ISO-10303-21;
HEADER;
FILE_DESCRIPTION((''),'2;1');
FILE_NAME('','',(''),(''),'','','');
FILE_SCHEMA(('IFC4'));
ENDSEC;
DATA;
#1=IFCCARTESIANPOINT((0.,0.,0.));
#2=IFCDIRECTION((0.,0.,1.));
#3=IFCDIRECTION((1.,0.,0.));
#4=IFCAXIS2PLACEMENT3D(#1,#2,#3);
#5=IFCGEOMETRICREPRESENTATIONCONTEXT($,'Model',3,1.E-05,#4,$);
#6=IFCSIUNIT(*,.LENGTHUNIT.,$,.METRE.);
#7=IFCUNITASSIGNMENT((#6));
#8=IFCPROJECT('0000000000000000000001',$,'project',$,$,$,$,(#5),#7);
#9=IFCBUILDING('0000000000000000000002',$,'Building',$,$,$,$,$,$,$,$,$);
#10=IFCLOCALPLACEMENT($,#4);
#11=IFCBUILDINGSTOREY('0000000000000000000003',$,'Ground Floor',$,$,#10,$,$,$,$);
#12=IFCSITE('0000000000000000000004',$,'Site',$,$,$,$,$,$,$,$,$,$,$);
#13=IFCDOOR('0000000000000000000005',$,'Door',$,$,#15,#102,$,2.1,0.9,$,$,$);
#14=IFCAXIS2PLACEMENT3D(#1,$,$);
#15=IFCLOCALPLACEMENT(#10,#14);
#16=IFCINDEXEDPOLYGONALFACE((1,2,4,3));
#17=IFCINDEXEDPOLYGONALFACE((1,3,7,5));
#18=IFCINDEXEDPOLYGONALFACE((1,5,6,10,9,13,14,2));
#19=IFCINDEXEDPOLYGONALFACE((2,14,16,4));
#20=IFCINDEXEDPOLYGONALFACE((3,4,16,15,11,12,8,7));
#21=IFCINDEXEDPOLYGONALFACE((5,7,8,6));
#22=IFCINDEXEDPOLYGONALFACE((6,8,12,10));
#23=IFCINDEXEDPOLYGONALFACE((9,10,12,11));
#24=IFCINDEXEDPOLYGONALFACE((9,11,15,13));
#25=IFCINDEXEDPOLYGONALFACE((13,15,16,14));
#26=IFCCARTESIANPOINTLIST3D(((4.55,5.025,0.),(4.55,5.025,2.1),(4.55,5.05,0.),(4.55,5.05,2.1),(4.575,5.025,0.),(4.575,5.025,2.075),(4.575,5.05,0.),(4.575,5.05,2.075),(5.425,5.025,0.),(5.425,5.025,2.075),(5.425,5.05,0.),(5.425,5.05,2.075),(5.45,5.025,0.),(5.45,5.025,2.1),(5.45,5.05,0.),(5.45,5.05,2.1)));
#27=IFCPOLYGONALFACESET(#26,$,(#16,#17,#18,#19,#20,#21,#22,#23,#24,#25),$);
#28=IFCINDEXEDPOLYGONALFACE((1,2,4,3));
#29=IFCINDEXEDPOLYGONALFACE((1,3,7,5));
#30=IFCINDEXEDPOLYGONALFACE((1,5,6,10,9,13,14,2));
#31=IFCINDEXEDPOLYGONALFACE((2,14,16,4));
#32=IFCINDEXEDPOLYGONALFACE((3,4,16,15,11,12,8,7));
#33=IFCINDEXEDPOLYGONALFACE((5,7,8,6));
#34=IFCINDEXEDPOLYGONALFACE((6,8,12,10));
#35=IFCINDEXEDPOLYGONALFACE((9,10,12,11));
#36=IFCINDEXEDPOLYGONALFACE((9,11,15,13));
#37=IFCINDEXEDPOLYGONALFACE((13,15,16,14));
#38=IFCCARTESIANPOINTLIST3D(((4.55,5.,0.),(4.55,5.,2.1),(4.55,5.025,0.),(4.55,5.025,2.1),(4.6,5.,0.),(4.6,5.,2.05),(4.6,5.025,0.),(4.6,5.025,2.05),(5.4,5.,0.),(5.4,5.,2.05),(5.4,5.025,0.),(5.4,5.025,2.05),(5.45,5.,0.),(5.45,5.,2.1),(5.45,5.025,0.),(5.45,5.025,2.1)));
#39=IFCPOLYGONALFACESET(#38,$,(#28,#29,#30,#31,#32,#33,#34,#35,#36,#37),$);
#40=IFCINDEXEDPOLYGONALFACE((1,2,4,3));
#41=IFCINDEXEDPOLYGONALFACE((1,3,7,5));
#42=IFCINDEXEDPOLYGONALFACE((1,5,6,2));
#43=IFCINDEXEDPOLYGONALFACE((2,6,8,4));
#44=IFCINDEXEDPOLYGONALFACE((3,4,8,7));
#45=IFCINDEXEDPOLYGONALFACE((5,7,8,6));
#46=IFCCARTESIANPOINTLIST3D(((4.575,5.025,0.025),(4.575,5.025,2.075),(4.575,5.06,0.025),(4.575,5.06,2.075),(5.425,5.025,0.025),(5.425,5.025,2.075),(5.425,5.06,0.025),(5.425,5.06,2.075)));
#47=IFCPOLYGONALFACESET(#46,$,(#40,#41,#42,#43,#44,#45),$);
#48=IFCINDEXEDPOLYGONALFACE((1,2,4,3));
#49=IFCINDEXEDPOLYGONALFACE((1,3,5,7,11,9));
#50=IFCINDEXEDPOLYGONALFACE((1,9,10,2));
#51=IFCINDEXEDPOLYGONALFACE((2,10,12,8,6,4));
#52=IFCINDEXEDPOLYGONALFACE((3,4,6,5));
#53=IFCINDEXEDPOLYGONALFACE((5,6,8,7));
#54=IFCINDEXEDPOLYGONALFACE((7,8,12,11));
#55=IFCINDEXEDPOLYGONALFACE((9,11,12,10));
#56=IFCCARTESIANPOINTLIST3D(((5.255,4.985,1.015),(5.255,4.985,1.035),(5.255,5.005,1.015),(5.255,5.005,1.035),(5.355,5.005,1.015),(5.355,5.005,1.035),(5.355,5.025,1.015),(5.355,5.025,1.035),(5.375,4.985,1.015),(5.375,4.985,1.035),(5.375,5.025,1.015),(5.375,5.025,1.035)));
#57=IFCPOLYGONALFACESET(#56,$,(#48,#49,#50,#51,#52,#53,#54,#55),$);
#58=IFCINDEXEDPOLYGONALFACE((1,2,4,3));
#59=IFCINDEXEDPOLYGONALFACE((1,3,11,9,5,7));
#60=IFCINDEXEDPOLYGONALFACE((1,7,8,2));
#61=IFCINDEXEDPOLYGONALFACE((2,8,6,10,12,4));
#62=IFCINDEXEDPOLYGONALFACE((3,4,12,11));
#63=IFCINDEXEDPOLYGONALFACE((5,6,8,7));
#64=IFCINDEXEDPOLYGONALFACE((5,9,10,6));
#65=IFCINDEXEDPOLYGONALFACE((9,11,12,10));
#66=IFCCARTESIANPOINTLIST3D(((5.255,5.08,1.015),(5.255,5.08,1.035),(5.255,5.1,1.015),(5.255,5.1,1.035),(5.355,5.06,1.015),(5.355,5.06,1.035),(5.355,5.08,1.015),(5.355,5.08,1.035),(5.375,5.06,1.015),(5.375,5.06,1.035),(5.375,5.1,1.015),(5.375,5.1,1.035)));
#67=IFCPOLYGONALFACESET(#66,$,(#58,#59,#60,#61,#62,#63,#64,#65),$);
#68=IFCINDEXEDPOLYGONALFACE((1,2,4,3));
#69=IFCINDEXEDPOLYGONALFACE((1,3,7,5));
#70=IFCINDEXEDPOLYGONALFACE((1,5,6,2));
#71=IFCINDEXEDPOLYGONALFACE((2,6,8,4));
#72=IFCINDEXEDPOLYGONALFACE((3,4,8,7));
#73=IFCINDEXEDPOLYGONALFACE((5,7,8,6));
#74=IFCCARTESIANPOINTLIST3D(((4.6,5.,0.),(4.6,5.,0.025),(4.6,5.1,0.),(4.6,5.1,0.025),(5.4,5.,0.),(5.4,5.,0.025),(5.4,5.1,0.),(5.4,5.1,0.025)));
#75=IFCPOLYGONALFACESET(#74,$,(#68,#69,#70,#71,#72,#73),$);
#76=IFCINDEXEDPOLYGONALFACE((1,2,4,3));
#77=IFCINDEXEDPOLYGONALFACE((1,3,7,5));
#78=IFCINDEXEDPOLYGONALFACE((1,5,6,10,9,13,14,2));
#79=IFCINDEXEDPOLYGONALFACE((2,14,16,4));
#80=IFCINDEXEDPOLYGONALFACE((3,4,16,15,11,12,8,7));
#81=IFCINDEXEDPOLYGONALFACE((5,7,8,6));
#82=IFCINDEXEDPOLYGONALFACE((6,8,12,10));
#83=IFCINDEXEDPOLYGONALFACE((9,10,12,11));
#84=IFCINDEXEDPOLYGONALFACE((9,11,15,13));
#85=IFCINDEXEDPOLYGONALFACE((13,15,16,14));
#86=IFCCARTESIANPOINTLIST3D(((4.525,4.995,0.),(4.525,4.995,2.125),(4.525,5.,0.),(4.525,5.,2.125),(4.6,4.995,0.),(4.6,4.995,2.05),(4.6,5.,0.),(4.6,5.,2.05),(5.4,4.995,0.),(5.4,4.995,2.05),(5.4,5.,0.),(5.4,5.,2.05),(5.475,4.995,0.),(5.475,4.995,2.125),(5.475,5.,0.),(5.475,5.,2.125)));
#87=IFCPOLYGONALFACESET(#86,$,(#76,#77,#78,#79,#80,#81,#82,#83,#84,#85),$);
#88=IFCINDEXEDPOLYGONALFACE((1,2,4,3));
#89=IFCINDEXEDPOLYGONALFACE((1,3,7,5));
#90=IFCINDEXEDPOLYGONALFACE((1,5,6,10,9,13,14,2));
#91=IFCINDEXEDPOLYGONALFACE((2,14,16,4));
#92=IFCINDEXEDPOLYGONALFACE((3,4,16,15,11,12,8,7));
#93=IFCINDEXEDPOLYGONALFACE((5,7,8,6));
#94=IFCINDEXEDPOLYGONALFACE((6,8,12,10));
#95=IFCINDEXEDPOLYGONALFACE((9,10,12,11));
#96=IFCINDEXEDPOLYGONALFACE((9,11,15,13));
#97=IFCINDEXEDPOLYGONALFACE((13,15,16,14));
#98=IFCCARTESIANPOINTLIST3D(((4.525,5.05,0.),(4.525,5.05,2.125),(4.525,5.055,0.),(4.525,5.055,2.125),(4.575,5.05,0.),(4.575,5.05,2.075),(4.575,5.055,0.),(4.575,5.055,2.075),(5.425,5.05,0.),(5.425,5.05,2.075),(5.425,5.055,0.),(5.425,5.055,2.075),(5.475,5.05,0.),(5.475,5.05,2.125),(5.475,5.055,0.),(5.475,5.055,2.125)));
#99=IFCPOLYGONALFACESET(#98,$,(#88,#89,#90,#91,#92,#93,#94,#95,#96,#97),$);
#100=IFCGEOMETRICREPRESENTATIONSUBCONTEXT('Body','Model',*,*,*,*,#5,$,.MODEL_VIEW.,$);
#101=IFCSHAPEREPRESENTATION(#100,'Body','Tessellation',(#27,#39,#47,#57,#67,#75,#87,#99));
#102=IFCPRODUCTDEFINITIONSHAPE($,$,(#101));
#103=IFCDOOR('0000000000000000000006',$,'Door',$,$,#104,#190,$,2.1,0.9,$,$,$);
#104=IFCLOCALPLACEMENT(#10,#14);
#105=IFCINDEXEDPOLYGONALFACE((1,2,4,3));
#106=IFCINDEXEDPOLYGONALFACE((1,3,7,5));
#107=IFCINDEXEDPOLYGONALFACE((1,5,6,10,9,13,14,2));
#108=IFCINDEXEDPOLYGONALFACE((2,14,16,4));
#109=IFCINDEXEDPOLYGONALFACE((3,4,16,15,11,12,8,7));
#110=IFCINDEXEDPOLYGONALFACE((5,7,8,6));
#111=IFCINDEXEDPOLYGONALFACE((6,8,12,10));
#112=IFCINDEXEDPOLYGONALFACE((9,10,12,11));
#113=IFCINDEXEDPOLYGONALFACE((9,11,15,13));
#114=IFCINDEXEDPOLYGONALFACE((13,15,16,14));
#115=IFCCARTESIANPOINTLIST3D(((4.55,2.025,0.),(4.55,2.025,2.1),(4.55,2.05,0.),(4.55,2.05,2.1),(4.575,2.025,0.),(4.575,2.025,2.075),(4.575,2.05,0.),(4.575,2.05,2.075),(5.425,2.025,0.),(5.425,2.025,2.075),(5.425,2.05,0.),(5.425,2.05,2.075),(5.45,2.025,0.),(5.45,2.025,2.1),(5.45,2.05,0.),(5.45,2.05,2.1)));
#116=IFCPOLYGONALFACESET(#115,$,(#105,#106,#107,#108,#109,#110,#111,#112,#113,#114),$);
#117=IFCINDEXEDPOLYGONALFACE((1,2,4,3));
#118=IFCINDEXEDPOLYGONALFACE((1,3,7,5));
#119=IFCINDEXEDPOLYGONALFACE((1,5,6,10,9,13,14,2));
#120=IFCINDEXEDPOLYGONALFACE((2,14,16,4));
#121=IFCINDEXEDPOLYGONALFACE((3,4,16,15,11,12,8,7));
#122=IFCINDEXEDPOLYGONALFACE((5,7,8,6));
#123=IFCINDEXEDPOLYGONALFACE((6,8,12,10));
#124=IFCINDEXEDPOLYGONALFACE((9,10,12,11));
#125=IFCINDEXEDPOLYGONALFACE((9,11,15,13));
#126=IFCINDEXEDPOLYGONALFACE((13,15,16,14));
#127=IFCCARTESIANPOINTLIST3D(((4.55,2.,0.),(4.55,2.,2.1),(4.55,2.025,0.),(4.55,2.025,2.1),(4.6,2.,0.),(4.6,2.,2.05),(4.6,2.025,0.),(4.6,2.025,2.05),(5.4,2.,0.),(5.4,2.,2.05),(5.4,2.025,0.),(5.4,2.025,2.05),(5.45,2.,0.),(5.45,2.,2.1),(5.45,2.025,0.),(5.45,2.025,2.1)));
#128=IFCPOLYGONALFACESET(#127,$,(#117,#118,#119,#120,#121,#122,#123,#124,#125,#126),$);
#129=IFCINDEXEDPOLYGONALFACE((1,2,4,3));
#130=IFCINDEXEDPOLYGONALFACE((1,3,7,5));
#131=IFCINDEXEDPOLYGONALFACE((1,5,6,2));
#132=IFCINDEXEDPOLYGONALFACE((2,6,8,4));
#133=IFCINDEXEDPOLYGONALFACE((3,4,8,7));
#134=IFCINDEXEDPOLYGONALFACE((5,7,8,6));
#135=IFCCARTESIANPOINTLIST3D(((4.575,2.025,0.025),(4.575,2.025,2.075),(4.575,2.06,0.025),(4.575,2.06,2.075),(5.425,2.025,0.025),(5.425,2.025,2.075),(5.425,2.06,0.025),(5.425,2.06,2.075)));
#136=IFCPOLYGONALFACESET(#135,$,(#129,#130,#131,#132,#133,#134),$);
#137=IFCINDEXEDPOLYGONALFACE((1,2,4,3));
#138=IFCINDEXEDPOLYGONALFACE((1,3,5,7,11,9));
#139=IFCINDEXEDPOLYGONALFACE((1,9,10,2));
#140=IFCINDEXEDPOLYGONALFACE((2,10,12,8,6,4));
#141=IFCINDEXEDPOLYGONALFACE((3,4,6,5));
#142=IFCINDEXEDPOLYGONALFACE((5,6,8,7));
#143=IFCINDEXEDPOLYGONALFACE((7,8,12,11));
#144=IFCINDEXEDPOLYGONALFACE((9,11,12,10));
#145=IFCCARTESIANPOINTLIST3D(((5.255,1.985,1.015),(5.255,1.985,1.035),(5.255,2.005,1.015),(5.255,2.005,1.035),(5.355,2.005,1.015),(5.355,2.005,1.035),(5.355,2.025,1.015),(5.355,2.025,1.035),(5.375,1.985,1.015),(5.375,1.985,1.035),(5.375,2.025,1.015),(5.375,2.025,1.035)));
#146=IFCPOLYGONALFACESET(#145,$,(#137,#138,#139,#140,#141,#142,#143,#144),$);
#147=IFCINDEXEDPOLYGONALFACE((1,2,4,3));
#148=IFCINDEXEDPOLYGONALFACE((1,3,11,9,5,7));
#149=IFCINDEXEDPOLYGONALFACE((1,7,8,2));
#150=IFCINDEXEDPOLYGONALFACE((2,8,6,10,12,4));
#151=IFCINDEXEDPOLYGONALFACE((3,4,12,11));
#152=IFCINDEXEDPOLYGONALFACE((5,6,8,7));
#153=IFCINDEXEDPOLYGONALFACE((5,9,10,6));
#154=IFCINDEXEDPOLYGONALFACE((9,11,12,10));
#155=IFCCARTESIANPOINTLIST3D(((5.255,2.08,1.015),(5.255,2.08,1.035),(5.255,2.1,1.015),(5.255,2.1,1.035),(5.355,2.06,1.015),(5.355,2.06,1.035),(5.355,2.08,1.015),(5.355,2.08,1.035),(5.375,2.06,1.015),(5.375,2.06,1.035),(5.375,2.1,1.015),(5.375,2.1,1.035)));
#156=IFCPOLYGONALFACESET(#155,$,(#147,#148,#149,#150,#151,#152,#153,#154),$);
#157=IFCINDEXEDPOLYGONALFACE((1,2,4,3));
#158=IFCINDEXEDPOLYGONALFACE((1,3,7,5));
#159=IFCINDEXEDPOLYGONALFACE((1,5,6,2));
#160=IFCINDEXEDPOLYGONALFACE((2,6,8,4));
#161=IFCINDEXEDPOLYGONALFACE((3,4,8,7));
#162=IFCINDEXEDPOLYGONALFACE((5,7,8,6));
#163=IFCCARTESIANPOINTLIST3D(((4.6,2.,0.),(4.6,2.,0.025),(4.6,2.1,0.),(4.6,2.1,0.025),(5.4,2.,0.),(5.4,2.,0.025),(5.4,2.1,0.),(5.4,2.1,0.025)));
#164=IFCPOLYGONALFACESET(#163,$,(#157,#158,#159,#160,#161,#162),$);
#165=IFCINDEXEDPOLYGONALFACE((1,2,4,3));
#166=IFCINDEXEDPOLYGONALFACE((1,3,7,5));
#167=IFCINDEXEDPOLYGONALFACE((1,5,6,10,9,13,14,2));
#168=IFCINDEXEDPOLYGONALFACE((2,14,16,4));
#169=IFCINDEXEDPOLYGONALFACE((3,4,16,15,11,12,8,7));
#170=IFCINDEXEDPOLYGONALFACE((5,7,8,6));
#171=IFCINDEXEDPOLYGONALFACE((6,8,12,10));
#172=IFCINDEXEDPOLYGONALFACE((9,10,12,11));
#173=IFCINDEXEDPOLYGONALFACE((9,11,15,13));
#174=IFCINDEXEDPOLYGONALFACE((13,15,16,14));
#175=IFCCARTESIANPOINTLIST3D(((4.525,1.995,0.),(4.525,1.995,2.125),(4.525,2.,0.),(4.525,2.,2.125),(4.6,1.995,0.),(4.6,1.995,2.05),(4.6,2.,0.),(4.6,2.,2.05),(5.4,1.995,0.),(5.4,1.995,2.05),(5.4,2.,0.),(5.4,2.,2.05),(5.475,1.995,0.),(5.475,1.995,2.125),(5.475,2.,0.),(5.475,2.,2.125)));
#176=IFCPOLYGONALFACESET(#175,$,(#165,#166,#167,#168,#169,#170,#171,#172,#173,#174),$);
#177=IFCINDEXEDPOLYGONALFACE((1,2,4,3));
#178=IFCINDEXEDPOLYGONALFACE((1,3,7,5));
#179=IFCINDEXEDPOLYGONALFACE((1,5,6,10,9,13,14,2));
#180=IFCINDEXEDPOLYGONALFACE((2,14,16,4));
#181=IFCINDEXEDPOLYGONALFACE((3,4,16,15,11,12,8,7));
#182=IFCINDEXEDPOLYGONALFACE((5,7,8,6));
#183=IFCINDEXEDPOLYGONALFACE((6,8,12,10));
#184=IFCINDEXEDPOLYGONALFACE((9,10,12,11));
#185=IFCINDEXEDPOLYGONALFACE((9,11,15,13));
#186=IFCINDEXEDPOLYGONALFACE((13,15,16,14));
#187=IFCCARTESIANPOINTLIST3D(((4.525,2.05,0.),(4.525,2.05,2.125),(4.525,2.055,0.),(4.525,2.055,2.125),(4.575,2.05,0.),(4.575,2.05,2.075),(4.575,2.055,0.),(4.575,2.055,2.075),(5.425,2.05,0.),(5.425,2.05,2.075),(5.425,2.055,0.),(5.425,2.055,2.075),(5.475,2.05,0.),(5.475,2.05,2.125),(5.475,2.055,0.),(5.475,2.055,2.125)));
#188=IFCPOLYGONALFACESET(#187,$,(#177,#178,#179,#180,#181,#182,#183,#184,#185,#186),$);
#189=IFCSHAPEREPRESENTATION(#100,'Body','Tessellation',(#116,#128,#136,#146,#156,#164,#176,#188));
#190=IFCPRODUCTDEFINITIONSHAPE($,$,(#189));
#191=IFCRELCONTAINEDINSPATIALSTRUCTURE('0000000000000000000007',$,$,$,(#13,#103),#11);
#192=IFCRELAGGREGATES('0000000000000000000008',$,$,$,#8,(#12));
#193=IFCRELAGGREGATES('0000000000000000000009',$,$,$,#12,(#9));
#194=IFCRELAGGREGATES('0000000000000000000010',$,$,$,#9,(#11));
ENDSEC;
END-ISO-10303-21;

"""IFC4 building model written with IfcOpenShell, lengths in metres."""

from ifc_helpers import new_model, si_unit, frame, origin_with_axes, place, context, subcontext, project, spatial, line, indexed_curve, outline, extrude, element, save


model = new_model("IFC4")

# Units and contexts
model_context = context("Model", 3, precision=1e-05, world=origin_with_axes())
body_context = subcontext(model_context, "Body", "Model", "MODEL_VIEW")
ifc_project = project(units=[si_unit("LENGTHUNIT", "METRE")], contexts=[model_context])

# Site, building, storey
site = spatial("IfcSite", under=ifc_project, Name="Site")
building = spatial("IfcBuilding", under=site, Name="Building")
storey_placement = place(None, origin_with_axes())
storey = spatial("IfcBuildingStorey", under=building, at=storey_placement, Name="Ground Floor")

# Doors
door_1_placement = place(storey_placement, frame((4.55, 5.0, 0.0), z_axis=(0.0, 0.0, 1.0), x_axis=(1.0, 0.0, 0.0)))
element("IfcDoor", 1, at=door_1_placement, inside=storey, Name="Door", OverallHeight=2.1, OverallWidth=0.9, context=body_context, shape_type="SweptSolid", body=[
    extrude(outline(indexed_curve([(0.0, 0.0), (0.0, 2.1), (0.9, 2.1), (0.9, 0.0), (0.875, 0.0), (0.875, 2.075), (0.025, 2.075), (0.025, 0.0)], segments=[line(1, 2, 3, 4, 5, 6, 7, 8, 1)])), frame((0.0, 0.025, 0.0), z_axis=(0.0, -1.0, 0.0), x_axis=(1.0, 0.0, 0.0)), (0.0, 0.0, -1.0), 0.025),
    extrude(outline(indexed_curve([(0.0, 0.0), (0.0, 2.1), (0.9, 2.1), (0.9, 0.0), (0.85, 0.0), (0.85, 2.05), (0.05, 2.05), (0.05, 0.0)], segments=[line(1, 2, 3, 4, 5, 6, 7, 8, 1)])), frame((0.0, 0.0, 0.0), z_axis=(0.0, -1.0, 0.0), x_axis=(1.0, 0.0, 0.0)), (0.0, 0.0, -1.0), 0.025),
    extrude(outline(indexed_curve([(0.0, 0.0), (0.85, 0.0), (0.85, 0.035), (0.0, 0.035)], segments=[line(1, 2, 3, 4, 1)])), frame((0.025, 0.025, 0.025), z_axis=(0.0, 0.0, 1.0), x_axis=(1.0, 0.0, 0.0)), (0.0, 0.0, 1.0), 2.05),
    extrude(outline(indexed_curve([(0.0, 0.0), (0.0, -0.04), (-0.12, -0.04), (-0.12, -0.02), (-0.02, -0.02), (-0.02, 0.0)], segments=[line(1, 2, 3, 4, 5, 6, 1)])), frame((0.825, 0.025, 1.015), z_axis=(0.0, 0.0, 1.0), x_axis=(1.0, 0.0, 0.0)), (0.0, 0.0, 1.0), 0.02),
    extrude(outline(indexed_curve([(0.0, 0.0), (0.0, 0.04), (-0.12, 0.04), (-0.12, 0.02), (-0.02, 0.02), (-0.02, 0.0)], segments=[line(1, 2, 3, 4, 5, 6, 1)])), frame((0.825, 0.06, 1.015), z_axis=(0.0, 0.0, 1.0), x_axis=(1.0, 0.0, 0.0)), (0.0, 0.0, 1.0), 0.02),
    extrude(outline(indexed_curve([(0.0, 0.0), (0.8, 0.0), (0.8, 0.1), (0.0, 0.1)], segments=[line(1, 2, 3, 4, 1)])), frame((0.05, 0.0, 0.0), z_axis=(0.0, 0.0, 1.0), x_axis=(1.0, 0.0, 0.0)), (0.0, 0.0, 1.0), 0.025),
    extrude(outline(indexed_curve([(0.0, 0.0), (0.0, 2.125), (0.95, 2.125), (0.95, 0.0), (0.875, 0.0), (0.875, 2.05), (0.075, 2.05), (0.075, 0.0)], segments=[line(1, 2, 3, 4, 5, 6, 7, 8, 1)])), frame((-0.025, -0.005, 0.0), z_axis=(0.0, -1.0, 0.0), x_axis=(1.0, 0.0, 0.0)), (0.0, 0.0, -1.0), 0.005),
    extrude(outline(indexed_curve([(0.0, 0.0), (0.0, 2.125), (0.95, 2.125), (0.95, 0.0), (0.9, 0.0), (0.9, 2.075), (0.05, 2.075), (0.05, 0.0)], segments=[line(1, 2, 3, 4, 5, 6, 7, 8, 1)])), frame((-0.025, 0.05, 0.0), z_axis=(0.0, -1.0, 0.0), x_axis=(1.0, 0.0, 0.0)), (0.0, 0.0, -1.0), 0.005),
])
door_2_placement = place(storey_placement, frame((4.55, 2.0, 0.0), z_axis=(0.0, 0.0, 1.0), x_axis=(1.0, 0.0, 0.0)))
element("IfcDoor", 2, at=door_2_placement, inside=storey, Name="Door", OverallHeight=2.1, OverallWidth=0.9, context=body_context, shape_type="SweptSolid", body=[
    extrude(outline(indexed_curve([(0.0, 0.0), (0.0, 2.1), (0.9, 2.1), (0.9, 0.0), (0.875, 0.0), (0.875, 2.075), (0.025, 2.075), (0.025, 0.0)], segments=[line(1, 2, 3, 4, 5, 6, 7, 8, 1)])), frame((0.0, 0.025, 0.0), z_axis=(0.0, -1.0, 0.0), x_axis=(1.0, 0.0, 0.0)), (0.0, 0.0, -1.0), 0.025),
    extrude(outline(indexed_curve([(0.0, 0.0), (0.0, 2.1), (0.9, 2.1), (0.9, 0.0), (0.85, 0.0), (0.85, 2.05), (0.05, 2.05), (0.05, 0.0)], segments=[line(1, 2, 3, 4, 5, 6, 7, 8, 1)])), frame((0.0, 0.0, 0.0), z_axis=(0.0, -1.0, 0.0), x_axis=(1.0, 0.0, 0.0)), (0.0, 0.0, -1.0), 0.025),
    extrude(outline(indexed_curve([(0.0, 0.0), (0.85, 0.0), (0.85, 0.035), (0.0, 0.035)], segments=[line(1, 2, 3, 4, 1)])), frame((0.025, 0.025, 0.025), z_axis=(0.0, 0.0, 1.0), x_axis=(1.0, 0.0, 0.0)), (0.0, 0.0, 1.0), 2.05),
    extrude(outline(indexed_curve([(0.0, 0.0), (0.0, -0.04), (-0.12, -0.04), (-0.12, -0.02), (-0.02, -0.02), (-0.02, 0.0)], segments=[line(1, 2, 3, 4, 5, 6, 1)])), frame((0.825, 0.025, 1.015), z_axis=(0.0, 0.0, 1.0), x_axis=(1.0, 0.0, 0.0)), (0.0, 0.0, 1.0), 0.02),
    extrude(outline(indexed_curve([(0.0, 0.0), (0.0, 0.04), (-0.12, 0.04), (-0.12, 0.02), (-0.02, 0.02), (-0.02, 0.0)], segments=[line(1, 2, 3, 4, 5, 6, 1)])), frame((0.825, 0.06, 1.015), z_axis=(0.0, 0.0, 1.0), x_axis=(1.0, 0.0, 0.0)), (0.0, 0.0, 1.0), 0.02),
    extrude(outline(indexed_curve([(0.0, 0.0), (0.8, 0.0), (0.8, 0.1), (0.0, 0.1)], segments=[line(1, 2, 3, 4, 1)])), frame((0.05, 0.0, 0.0), z_axis=(0.0, 0.0, 1.0), x_axis=(1.0, 0.0, 0.0)), (0.0, 0.0, 1.0), 0.025),
    extrude(outline(indexed_curve([(0.0, 0.0), (0.0, 2.125), (0.95, 2.125), (0.95, 0.0), (0.875, 0.0), (0.875, 2.05), (0.075, 2.05), (0.075, 0.0)], segments=[line(1, 2, 3, 4, 5, 6, 7, 8, 1)])), frame((-0.025, -0.005, 0.0), z_axis=(0.0, -1.0, 0.0), x_axis=(1.0, 0.0, 0.0)), (0.0, 0.0, -1.0), 0.005),
    extrude(outline(indexed_curve([(0.0, 0.0), (0.0, 2.125), (0.95, 2.125), (0.95, 0.0), (0.9, 0.0), (0.9, 2.075), (0.05, 2.075), (0.05, 0.0)], segments=[line(1, 2, 3, 4, 5, 6, 7, 8, 1)])), frame((-0.025, 0.05, 0.0), z_axis=(0.0, -1.0, 0.0), x_axis=(1.0, 0.0, 0.0)), (0.0, 0.0, -1.0), 0.005),
])

save(model, "model.ifc")
